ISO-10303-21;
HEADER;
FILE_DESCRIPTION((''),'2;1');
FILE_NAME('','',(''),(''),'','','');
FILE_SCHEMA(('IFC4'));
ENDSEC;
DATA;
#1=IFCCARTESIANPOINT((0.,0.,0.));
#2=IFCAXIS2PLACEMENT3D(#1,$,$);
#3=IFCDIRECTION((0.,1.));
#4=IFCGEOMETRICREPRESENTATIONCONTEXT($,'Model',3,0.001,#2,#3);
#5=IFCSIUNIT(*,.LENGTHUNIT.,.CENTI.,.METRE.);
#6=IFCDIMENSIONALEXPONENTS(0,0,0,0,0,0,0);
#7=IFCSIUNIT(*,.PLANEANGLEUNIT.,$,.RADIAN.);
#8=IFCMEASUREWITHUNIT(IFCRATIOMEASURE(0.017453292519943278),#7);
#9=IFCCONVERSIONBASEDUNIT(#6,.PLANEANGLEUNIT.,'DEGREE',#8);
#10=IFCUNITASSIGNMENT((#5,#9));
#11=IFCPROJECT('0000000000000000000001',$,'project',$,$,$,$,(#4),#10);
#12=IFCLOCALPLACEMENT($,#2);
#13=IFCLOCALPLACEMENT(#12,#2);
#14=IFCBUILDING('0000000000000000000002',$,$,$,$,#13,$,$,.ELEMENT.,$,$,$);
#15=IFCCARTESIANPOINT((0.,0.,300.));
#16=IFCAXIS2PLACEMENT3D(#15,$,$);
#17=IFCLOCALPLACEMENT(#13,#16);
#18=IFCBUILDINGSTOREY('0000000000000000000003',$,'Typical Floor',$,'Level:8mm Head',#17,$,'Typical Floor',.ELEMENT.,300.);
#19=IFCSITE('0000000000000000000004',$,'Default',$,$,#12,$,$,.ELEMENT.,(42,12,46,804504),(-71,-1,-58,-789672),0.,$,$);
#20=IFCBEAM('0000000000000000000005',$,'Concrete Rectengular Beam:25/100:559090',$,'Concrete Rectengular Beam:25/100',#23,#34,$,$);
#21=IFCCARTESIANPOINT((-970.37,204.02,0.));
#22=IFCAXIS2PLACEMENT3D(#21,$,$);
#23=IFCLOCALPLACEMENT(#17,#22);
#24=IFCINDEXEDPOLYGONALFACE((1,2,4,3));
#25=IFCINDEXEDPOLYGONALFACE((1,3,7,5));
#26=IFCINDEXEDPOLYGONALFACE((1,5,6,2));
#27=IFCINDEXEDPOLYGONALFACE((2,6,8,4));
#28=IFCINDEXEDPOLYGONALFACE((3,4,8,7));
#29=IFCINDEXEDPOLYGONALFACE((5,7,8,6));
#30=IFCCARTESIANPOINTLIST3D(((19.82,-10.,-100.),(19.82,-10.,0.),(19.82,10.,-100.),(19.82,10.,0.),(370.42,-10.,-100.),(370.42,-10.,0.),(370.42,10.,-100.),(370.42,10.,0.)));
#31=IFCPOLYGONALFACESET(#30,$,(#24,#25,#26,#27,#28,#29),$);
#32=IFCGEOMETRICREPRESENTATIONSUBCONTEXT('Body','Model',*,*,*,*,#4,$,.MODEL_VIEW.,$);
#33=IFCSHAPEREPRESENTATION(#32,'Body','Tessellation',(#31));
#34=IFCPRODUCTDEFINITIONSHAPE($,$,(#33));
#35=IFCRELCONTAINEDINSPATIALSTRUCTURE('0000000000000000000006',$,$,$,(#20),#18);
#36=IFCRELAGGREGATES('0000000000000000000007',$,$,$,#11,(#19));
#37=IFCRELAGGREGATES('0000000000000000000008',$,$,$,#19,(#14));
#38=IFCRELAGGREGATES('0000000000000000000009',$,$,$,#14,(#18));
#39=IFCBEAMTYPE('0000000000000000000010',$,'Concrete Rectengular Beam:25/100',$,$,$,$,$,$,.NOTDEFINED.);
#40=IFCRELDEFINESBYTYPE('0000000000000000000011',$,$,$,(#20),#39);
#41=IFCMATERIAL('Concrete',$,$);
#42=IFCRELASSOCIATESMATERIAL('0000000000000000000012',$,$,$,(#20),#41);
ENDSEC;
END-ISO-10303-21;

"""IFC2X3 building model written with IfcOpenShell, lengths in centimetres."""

from ifc_helpers import new_model, entity, si_unit, converted_unit, direction, frame, frame_2d, origin, place, context, subcontext, project, spatial, rectangle, extrude, material, type_object, element, save


model = new_model("IFC2X3")

# Units and contexts
model_context = context("Model", 3, precision=0.001, world=origin(), true_north=direction((0.0, 1.0)))
body_context = subcontext(model_context, "Body", "Model", "MODEL_VIEW")
ifc_project = project(units=[si_unit("LENGTHUNIT", "METRE", prefix="CENTI"), converted_unit("PLANEANGLEUNIT", "DEGREE", entity("IfcRatioMeasure", 0.017453292519943278), si_unit("PLANEANGLEUNIT", "RADIAN"), dimensions=[0, 0, 0, 0, 0, 0, 0])], contexts=[model_context])

# Site, building, storey
site_placement = place(None, origin())
site = spatial("IfcSite", under=ifc_project, at=site_placement, Name="Default", CompositionType="ELEMENT", RefLatitude=(42, 12, 46, 804504), RefLongitude=(-71, -1, -58, -789672), RefElevation=0.0)
building_placement = place(site_placement, origin())
building = spatial("IfcBuilding", under=site, at=building_placement, CompositionType="ELEMENT")
storey_placement = place(building_placement, frame((0.0, 0.0, 300.0)))
storey = spatial("IfcBuildingStorey", under=building, at=storey_placement, Name="Typical Floor", ObjectType="Level:8mm Head", LongName="Typical Floor", CompositionType="ELEMENT", Elevation=300.0)

# Beam
ifc_material = material(Name="Concrete")
beam_type_1 = type_object("IfcBeamType", Name="Concrete Rectengular Beam:25/100", PredefinedType="NOTDEFINED")
beam_1_placement = place(storey_placement, frame((-970.37, 204.02, 0.0)))
element("IfcBeam", 1, at=beam_1_placement, inside=storey, type_object=beam_type_1, material=ifc_material, Name="Concrete Rectengular Beam:25/100:559090", ObjectType="Concrete Rectengular Beam:25/100", context=body_context, shape_type="SweptSolid", body=[
    extrude(rectangle(XDim=100.0, YDim=20.0, at=frame_2d((0.0, 0.0), x_axis=(1.0, 0.0))), frame((19.82, 0.0, -50.0), z_axis=(1.0, 0.0, 0.0), x_axis=(0.0, 0.0, -1.0)), (0.0, 0.0, 1.0), 350.61),
])

save(model, "model.ifc")
